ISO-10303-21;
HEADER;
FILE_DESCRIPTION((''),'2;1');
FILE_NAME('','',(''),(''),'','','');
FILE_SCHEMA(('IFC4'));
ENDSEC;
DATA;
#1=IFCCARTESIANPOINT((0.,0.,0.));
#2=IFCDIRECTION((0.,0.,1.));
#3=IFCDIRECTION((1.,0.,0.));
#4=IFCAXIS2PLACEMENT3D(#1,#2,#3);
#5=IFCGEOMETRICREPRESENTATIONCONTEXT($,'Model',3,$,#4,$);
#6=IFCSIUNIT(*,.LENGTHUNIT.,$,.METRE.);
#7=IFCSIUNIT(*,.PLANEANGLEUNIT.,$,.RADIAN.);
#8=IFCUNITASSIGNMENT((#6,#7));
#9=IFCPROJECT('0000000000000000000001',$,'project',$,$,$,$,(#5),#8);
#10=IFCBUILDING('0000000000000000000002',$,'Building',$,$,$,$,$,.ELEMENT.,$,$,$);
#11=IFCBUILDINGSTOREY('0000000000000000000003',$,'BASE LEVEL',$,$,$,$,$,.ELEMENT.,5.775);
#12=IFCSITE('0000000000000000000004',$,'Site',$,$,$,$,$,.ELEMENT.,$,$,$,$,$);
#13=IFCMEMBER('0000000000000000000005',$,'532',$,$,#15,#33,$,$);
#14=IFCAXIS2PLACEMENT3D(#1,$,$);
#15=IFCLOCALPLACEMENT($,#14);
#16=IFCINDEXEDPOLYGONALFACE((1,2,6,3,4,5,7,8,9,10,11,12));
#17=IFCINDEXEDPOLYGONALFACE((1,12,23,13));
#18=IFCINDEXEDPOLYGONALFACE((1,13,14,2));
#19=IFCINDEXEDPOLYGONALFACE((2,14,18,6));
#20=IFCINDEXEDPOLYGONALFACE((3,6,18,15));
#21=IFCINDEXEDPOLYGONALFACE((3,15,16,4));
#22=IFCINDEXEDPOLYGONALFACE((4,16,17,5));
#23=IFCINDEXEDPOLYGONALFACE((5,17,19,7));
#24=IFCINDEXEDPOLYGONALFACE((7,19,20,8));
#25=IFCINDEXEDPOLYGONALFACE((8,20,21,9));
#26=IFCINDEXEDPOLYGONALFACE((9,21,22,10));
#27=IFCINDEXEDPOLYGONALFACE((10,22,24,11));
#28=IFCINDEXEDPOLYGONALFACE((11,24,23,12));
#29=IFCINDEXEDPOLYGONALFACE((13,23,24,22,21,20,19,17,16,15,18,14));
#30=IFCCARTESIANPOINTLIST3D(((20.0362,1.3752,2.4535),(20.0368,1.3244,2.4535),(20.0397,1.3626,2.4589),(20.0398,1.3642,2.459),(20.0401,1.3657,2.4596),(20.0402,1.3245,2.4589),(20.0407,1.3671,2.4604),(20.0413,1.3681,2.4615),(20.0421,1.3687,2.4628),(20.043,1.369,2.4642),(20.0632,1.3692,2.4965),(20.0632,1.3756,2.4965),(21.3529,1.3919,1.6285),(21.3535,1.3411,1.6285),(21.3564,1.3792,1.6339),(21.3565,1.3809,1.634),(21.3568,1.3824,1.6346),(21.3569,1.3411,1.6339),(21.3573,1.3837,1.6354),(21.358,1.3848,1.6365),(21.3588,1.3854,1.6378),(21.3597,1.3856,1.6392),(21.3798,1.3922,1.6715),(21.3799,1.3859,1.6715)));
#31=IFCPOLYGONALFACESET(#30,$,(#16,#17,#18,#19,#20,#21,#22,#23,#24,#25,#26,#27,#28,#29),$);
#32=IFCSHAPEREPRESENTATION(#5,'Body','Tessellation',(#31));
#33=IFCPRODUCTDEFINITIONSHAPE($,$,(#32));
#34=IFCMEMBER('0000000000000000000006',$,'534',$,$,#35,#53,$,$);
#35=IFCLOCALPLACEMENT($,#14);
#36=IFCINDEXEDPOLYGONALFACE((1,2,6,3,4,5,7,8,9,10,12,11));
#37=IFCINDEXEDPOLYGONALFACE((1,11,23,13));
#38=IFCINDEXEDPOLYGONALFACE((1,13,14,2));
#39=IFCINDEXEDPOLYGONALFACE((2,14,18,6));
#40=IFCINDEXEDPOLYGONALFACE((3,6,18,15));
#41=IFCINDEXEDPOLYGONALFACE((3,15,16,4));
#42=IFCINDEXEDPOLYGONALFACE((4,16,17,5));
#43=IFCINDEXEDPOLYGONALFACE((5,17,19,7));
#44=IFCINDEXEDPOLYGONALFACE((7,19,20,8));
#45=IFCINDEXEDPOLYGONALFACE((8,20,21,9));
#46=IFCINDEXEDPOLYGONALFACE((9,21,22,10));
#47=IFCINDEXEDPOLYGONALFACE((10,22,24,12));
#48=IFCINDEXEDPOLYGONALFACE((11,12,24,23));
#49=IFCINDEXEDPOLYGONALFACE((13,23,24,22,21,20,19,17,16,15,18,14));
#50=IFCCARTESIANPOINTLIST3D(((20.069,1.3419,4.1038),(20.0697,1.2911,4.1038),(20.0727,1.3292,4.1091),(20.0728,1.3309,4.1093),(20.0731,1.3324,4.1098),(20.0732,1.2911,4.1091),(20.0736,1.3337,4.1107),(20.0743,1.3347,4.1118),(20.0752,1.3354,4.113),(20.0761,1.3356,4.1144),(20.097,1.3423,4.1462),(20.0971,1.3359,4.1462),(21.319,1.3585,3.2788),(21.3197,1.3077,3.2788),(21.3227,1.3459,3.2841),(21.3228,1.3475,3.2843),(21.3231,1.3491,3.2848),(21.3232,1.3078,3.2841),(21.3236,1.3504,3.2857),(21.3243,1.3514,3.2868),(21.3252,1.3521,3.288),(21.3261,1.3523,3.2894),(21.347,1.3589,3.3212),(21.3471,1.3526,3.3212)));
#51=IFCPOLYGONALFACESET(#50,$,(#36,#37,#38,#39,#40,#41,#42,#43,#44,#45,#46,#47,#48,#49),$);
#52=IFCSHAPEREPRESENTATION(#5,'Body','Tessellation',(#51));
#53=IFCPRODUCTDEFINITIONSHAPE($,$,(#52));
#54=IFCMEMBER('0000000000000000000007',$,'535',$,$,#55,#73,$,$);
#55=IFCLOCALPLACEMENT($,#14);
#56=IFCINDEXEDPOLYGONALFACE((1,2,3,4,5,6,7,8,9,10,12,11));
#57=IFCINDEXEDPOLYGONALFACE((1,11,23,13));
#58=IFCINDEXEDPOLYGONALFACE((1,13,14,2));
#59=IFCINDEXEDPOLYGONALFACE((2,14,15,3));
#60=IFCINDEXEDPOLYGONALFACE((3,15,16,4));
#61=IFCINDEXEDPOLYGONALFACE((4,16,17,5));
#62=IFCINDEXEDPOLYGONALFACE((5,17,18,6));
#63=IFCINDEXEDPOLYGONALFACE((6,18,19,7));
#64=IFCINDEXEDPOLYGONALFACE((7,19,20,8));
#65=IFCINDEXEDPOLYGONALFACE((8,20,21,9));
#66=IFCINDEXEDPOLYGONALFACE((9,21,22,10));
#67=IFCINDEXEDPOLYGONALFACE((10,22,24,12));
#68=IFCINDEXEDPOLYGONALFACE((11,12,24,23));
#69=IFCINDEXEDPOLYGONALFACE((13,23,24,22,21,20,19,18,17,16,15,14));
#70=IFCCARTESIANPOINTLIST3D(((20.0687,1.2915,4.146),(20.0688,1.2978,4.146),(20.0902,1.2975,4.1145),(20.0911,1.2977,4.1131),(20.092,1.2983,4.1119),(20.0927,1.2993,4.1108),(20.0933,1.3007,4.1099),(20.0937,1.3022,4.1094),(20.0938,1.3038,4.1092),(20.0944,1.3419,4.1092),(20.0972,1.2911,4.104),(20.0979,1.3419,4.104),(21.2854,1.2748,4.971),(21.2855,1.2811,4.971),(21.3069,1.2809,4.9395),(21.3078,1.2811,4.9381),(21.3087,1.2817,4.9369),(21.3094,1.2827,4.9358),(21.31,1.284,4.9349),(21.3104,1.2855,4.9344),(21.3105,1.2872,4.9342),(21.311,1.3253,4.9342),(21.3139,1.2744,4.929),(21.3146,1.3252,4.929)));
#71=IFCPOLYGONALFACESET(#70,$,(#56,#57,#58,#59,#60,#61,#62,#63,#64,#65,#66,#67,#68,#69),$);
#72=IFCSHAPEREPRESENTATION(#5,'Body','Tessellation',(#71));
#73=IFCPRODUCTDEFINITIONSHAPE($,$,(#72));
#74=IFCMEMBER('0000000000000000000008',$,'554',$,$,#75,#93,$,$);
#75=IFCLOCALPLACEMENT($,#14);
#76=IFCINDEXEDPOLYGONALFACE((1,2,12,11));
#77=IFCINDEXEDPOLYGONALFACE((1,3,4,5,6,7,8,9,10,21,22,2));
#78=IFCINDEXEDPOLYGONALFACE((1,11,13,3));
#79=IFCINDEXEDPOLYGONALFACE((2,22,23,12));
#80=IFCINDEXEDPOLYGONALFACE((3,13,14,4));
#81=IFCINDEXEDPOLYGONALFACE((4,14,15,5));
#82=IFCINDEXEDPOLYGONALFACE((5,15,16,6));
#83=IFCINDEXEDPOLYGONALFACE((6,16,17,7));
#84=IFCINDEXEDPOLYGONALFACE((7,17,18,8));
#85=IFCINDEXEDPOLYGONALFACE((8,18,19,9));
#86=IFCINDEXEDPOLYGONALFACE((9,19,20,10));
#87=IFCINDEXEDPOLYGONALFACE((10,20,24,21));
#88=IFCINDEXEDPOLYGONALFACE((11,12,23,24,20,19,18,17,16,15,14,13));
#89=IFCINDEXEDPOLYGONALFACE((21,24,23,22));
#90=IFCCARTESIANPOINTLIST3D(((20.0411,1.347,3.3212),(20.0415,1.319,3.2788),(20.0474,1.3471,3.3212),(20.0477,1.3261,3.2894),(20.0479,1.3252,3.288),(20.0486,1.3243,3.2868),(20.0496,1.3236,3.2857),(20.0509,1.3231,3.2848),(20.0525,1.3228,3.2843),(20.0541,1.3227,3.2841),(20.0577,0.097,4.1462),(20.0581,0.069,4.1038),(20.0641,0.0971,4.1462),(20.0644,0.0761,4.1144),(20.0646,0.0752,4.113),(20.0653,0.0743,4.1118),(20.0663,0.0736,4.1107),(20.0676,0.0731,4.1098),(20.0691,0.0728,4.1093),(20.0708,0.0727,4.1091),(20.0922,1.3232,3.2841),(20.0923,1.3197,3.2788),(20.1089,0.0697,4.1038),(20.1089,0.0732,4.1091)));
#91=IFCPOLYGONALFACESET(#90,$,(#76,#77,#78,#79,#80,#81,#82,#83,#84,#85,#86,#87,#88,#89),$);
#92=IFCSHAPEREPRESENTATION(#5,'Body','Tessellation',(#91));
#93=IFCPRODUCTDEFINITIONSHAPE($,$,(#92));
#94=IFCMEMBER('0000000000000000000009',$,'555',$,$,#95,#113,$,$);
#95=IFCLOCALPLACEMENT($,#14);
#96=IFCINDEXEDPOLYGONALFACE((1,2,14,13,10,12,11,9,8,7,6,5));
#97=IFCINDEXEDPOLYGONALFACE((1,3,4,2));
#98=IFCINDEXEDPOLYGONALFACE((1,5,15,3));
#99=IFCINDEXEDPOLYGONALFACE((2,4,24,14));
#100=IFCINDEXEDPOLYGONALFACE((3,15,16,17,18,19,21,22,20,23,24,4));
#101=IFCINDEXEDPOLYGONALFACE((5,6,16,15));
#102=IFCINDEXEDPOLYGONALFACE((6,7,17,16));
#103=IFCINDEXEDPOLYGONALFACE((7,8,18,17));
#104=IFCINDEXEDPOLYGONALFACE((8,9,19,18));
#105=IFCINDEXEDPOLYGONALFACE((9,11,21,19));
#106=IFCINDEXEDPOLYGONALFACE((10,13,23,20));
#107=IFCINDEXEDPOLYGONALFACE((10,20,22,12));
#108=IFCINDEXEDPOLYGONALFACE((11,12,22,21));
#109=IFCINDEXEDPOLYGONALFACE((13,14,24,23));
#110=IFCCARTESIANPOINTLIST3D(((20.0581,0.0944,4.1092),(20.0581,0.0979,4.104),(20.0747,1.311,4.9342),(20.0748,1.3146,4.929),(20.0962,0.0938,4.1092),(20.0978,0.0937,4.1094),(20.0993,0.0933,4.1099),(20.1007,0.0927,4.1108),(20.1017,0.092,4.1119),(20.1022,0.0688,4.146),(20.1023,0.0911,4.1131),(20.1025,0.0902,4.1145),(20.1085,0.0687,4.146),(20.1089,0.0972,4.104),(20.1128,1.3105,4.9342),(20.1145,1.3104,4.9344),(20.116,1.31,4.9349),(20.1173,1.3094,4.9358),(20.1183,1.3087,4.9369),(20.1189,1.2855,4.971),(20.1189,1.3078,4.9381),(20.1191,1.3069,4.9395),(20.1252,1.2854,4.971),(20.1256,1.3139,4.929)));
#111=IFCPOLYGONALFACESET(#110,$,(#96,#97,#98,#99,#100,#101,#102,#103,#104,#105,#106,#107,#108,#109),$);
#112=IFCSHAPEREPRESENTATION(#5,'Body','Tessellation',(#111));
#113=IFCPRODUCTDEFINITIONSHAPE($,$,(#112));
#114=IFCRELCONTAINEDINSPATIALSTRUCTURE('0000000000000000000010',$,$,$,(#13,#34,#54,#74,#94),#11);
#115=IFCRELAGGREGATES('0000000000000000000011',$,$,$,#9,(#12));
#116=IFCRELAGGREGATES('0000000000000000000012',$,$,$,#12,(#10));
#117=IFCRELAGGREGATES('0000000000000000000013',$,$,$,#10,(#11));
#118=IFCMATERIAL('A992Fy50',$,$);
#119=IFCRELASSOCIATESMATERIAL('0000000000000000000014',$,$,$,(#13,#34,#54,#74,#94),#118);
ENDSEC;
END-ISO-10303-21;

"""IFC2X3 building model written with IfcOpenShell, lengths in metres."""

from ifc_helpers import new_model, si_unit, frame, origin_with_axes, origin_2d_with_axis, place, context, project, spatial, l_section, extrude, material, element, save


model = new_model("IFC2X3")

# Units and contexts
model_context = context("Model", 3, world=origin_with_axes())
ifc_project = project(units=[si_unit("LENGTHUNIT", "METRE"), si_unit("PLANEANGLEUNIT", "RADIAN")], contexts=[model_context])

# Site, building, storey
site = spatial("IfcSite", under=ifc_project, Name="Site", CompositionType="ELEMENT")
building = spatial("IfcBuilding", under=site, Name="Building", CompositionType="ELEMENT")
storey = spatial("IfcBuildingStorey", under=building, Name="BASE LEVEL", CompositionType="ELEMENT", Elevation=5.775)

# Members
ifc_material = material(Name="A992Fy50")
member_1_placement = place(None, frame((21.3667, 1.3667, 1.65), z_axis=(-0.847346, -0.010726, 0.530932), x_axis=(0.013332, -0.999911, 0.0)))
element("IfcMember", 1, at=member_1_placement, inside=storey, material=ifc_material, Name="532", context=model_context, shape_type="SweptSolid", body=[
    extrude(l_section(Depth=0.0508, Width=0.0508, Thickness=0.0063, FilletRadius=0.0063, at=origin_2d_with_axis()), origin_with_axes(), (0.0, 0.0, 1.0), 1.5539),
])
member_2_placement = place(None, frame((21.3333, 1.3333, 3.3), z_axis=(-0.834558, -0.011127, 0.550808), x_axis=(0.013332, -0.999911, 0.0)))
element("IfcMember", 2, at=member_2_placement, inside=storey, material=ifc_material, Name="534", context=model_context, shape_type="SweptSolid", body=[
    extrude(l_section(Depth=0.0508, Width=0.0508, Thickness=0.0063, FilletRadius=0.0063, at=origin_2d_with_axis()), origin_with_axes(), (0.0, 0.0, 1.0), 1.4978),
])
member_3_placement = place(None, frame((20.0833, 1.3167, 4.125), z_axis=(0.827611, -0.011337, 0.561188), x_axis=(0.013697, 0.999906, 0.0)))
element("IfcMember", 3, at=member_3_placement, inside=storey, material=ifc_material, Name="535", context=model_context, shape_type="SweptSolid", body=[
    extrude(l_section(Depth=0.0508, Width=0.0508, Thickness=0.0063, FilletRadius=0.0063, at=origin_2d_with_axis()), origin_with_axes(), (0.0, 0.0, 1.0), 1.4701),
])
member_4_placement = place(None, frame((20.0667, 1.3333, 3.3), z_axis=(0.011127, -0.834558, 0.550808), x_axis=(0.999911, 0.013332, 0.0)))
element("IfcMember", 4, at=member_4_placement, inside=storey, material=ifc_material, Name="554", context=model_context, shape_type="SweptSolid", body=[
    extrude(l_section(Depth=0.0508, Width=0.0508, Thickness=0.0063, FilletRadius=0.0063, at=origin_2d_with_axis()), origin_with_axes(), (0.0, 0.0, 1.0), 1.4978),
])
member_5_placement = place(None, frame((20.0833, 0.0833, 4.125), z_axis=(0.011337, 0.827611, 0.561188), x_axis=(-0.999906, 0.013697, 0.0)))
element("IfcMember", 5, at=member_5_placement, inside=storey, material=ifc_material, Name="555", context=model_context, shape_type="SweptSolid", body=[
    extrude(l_section(Depth=0.0508, Width=0.0508, Thickness=0.0063, FilletRadius=0.0063, at=origin_2d_with_axis()), origin_with_axes(), (0.0, 0.0, 1.0), 1.4701),
])

save(model, "model.ifc")
